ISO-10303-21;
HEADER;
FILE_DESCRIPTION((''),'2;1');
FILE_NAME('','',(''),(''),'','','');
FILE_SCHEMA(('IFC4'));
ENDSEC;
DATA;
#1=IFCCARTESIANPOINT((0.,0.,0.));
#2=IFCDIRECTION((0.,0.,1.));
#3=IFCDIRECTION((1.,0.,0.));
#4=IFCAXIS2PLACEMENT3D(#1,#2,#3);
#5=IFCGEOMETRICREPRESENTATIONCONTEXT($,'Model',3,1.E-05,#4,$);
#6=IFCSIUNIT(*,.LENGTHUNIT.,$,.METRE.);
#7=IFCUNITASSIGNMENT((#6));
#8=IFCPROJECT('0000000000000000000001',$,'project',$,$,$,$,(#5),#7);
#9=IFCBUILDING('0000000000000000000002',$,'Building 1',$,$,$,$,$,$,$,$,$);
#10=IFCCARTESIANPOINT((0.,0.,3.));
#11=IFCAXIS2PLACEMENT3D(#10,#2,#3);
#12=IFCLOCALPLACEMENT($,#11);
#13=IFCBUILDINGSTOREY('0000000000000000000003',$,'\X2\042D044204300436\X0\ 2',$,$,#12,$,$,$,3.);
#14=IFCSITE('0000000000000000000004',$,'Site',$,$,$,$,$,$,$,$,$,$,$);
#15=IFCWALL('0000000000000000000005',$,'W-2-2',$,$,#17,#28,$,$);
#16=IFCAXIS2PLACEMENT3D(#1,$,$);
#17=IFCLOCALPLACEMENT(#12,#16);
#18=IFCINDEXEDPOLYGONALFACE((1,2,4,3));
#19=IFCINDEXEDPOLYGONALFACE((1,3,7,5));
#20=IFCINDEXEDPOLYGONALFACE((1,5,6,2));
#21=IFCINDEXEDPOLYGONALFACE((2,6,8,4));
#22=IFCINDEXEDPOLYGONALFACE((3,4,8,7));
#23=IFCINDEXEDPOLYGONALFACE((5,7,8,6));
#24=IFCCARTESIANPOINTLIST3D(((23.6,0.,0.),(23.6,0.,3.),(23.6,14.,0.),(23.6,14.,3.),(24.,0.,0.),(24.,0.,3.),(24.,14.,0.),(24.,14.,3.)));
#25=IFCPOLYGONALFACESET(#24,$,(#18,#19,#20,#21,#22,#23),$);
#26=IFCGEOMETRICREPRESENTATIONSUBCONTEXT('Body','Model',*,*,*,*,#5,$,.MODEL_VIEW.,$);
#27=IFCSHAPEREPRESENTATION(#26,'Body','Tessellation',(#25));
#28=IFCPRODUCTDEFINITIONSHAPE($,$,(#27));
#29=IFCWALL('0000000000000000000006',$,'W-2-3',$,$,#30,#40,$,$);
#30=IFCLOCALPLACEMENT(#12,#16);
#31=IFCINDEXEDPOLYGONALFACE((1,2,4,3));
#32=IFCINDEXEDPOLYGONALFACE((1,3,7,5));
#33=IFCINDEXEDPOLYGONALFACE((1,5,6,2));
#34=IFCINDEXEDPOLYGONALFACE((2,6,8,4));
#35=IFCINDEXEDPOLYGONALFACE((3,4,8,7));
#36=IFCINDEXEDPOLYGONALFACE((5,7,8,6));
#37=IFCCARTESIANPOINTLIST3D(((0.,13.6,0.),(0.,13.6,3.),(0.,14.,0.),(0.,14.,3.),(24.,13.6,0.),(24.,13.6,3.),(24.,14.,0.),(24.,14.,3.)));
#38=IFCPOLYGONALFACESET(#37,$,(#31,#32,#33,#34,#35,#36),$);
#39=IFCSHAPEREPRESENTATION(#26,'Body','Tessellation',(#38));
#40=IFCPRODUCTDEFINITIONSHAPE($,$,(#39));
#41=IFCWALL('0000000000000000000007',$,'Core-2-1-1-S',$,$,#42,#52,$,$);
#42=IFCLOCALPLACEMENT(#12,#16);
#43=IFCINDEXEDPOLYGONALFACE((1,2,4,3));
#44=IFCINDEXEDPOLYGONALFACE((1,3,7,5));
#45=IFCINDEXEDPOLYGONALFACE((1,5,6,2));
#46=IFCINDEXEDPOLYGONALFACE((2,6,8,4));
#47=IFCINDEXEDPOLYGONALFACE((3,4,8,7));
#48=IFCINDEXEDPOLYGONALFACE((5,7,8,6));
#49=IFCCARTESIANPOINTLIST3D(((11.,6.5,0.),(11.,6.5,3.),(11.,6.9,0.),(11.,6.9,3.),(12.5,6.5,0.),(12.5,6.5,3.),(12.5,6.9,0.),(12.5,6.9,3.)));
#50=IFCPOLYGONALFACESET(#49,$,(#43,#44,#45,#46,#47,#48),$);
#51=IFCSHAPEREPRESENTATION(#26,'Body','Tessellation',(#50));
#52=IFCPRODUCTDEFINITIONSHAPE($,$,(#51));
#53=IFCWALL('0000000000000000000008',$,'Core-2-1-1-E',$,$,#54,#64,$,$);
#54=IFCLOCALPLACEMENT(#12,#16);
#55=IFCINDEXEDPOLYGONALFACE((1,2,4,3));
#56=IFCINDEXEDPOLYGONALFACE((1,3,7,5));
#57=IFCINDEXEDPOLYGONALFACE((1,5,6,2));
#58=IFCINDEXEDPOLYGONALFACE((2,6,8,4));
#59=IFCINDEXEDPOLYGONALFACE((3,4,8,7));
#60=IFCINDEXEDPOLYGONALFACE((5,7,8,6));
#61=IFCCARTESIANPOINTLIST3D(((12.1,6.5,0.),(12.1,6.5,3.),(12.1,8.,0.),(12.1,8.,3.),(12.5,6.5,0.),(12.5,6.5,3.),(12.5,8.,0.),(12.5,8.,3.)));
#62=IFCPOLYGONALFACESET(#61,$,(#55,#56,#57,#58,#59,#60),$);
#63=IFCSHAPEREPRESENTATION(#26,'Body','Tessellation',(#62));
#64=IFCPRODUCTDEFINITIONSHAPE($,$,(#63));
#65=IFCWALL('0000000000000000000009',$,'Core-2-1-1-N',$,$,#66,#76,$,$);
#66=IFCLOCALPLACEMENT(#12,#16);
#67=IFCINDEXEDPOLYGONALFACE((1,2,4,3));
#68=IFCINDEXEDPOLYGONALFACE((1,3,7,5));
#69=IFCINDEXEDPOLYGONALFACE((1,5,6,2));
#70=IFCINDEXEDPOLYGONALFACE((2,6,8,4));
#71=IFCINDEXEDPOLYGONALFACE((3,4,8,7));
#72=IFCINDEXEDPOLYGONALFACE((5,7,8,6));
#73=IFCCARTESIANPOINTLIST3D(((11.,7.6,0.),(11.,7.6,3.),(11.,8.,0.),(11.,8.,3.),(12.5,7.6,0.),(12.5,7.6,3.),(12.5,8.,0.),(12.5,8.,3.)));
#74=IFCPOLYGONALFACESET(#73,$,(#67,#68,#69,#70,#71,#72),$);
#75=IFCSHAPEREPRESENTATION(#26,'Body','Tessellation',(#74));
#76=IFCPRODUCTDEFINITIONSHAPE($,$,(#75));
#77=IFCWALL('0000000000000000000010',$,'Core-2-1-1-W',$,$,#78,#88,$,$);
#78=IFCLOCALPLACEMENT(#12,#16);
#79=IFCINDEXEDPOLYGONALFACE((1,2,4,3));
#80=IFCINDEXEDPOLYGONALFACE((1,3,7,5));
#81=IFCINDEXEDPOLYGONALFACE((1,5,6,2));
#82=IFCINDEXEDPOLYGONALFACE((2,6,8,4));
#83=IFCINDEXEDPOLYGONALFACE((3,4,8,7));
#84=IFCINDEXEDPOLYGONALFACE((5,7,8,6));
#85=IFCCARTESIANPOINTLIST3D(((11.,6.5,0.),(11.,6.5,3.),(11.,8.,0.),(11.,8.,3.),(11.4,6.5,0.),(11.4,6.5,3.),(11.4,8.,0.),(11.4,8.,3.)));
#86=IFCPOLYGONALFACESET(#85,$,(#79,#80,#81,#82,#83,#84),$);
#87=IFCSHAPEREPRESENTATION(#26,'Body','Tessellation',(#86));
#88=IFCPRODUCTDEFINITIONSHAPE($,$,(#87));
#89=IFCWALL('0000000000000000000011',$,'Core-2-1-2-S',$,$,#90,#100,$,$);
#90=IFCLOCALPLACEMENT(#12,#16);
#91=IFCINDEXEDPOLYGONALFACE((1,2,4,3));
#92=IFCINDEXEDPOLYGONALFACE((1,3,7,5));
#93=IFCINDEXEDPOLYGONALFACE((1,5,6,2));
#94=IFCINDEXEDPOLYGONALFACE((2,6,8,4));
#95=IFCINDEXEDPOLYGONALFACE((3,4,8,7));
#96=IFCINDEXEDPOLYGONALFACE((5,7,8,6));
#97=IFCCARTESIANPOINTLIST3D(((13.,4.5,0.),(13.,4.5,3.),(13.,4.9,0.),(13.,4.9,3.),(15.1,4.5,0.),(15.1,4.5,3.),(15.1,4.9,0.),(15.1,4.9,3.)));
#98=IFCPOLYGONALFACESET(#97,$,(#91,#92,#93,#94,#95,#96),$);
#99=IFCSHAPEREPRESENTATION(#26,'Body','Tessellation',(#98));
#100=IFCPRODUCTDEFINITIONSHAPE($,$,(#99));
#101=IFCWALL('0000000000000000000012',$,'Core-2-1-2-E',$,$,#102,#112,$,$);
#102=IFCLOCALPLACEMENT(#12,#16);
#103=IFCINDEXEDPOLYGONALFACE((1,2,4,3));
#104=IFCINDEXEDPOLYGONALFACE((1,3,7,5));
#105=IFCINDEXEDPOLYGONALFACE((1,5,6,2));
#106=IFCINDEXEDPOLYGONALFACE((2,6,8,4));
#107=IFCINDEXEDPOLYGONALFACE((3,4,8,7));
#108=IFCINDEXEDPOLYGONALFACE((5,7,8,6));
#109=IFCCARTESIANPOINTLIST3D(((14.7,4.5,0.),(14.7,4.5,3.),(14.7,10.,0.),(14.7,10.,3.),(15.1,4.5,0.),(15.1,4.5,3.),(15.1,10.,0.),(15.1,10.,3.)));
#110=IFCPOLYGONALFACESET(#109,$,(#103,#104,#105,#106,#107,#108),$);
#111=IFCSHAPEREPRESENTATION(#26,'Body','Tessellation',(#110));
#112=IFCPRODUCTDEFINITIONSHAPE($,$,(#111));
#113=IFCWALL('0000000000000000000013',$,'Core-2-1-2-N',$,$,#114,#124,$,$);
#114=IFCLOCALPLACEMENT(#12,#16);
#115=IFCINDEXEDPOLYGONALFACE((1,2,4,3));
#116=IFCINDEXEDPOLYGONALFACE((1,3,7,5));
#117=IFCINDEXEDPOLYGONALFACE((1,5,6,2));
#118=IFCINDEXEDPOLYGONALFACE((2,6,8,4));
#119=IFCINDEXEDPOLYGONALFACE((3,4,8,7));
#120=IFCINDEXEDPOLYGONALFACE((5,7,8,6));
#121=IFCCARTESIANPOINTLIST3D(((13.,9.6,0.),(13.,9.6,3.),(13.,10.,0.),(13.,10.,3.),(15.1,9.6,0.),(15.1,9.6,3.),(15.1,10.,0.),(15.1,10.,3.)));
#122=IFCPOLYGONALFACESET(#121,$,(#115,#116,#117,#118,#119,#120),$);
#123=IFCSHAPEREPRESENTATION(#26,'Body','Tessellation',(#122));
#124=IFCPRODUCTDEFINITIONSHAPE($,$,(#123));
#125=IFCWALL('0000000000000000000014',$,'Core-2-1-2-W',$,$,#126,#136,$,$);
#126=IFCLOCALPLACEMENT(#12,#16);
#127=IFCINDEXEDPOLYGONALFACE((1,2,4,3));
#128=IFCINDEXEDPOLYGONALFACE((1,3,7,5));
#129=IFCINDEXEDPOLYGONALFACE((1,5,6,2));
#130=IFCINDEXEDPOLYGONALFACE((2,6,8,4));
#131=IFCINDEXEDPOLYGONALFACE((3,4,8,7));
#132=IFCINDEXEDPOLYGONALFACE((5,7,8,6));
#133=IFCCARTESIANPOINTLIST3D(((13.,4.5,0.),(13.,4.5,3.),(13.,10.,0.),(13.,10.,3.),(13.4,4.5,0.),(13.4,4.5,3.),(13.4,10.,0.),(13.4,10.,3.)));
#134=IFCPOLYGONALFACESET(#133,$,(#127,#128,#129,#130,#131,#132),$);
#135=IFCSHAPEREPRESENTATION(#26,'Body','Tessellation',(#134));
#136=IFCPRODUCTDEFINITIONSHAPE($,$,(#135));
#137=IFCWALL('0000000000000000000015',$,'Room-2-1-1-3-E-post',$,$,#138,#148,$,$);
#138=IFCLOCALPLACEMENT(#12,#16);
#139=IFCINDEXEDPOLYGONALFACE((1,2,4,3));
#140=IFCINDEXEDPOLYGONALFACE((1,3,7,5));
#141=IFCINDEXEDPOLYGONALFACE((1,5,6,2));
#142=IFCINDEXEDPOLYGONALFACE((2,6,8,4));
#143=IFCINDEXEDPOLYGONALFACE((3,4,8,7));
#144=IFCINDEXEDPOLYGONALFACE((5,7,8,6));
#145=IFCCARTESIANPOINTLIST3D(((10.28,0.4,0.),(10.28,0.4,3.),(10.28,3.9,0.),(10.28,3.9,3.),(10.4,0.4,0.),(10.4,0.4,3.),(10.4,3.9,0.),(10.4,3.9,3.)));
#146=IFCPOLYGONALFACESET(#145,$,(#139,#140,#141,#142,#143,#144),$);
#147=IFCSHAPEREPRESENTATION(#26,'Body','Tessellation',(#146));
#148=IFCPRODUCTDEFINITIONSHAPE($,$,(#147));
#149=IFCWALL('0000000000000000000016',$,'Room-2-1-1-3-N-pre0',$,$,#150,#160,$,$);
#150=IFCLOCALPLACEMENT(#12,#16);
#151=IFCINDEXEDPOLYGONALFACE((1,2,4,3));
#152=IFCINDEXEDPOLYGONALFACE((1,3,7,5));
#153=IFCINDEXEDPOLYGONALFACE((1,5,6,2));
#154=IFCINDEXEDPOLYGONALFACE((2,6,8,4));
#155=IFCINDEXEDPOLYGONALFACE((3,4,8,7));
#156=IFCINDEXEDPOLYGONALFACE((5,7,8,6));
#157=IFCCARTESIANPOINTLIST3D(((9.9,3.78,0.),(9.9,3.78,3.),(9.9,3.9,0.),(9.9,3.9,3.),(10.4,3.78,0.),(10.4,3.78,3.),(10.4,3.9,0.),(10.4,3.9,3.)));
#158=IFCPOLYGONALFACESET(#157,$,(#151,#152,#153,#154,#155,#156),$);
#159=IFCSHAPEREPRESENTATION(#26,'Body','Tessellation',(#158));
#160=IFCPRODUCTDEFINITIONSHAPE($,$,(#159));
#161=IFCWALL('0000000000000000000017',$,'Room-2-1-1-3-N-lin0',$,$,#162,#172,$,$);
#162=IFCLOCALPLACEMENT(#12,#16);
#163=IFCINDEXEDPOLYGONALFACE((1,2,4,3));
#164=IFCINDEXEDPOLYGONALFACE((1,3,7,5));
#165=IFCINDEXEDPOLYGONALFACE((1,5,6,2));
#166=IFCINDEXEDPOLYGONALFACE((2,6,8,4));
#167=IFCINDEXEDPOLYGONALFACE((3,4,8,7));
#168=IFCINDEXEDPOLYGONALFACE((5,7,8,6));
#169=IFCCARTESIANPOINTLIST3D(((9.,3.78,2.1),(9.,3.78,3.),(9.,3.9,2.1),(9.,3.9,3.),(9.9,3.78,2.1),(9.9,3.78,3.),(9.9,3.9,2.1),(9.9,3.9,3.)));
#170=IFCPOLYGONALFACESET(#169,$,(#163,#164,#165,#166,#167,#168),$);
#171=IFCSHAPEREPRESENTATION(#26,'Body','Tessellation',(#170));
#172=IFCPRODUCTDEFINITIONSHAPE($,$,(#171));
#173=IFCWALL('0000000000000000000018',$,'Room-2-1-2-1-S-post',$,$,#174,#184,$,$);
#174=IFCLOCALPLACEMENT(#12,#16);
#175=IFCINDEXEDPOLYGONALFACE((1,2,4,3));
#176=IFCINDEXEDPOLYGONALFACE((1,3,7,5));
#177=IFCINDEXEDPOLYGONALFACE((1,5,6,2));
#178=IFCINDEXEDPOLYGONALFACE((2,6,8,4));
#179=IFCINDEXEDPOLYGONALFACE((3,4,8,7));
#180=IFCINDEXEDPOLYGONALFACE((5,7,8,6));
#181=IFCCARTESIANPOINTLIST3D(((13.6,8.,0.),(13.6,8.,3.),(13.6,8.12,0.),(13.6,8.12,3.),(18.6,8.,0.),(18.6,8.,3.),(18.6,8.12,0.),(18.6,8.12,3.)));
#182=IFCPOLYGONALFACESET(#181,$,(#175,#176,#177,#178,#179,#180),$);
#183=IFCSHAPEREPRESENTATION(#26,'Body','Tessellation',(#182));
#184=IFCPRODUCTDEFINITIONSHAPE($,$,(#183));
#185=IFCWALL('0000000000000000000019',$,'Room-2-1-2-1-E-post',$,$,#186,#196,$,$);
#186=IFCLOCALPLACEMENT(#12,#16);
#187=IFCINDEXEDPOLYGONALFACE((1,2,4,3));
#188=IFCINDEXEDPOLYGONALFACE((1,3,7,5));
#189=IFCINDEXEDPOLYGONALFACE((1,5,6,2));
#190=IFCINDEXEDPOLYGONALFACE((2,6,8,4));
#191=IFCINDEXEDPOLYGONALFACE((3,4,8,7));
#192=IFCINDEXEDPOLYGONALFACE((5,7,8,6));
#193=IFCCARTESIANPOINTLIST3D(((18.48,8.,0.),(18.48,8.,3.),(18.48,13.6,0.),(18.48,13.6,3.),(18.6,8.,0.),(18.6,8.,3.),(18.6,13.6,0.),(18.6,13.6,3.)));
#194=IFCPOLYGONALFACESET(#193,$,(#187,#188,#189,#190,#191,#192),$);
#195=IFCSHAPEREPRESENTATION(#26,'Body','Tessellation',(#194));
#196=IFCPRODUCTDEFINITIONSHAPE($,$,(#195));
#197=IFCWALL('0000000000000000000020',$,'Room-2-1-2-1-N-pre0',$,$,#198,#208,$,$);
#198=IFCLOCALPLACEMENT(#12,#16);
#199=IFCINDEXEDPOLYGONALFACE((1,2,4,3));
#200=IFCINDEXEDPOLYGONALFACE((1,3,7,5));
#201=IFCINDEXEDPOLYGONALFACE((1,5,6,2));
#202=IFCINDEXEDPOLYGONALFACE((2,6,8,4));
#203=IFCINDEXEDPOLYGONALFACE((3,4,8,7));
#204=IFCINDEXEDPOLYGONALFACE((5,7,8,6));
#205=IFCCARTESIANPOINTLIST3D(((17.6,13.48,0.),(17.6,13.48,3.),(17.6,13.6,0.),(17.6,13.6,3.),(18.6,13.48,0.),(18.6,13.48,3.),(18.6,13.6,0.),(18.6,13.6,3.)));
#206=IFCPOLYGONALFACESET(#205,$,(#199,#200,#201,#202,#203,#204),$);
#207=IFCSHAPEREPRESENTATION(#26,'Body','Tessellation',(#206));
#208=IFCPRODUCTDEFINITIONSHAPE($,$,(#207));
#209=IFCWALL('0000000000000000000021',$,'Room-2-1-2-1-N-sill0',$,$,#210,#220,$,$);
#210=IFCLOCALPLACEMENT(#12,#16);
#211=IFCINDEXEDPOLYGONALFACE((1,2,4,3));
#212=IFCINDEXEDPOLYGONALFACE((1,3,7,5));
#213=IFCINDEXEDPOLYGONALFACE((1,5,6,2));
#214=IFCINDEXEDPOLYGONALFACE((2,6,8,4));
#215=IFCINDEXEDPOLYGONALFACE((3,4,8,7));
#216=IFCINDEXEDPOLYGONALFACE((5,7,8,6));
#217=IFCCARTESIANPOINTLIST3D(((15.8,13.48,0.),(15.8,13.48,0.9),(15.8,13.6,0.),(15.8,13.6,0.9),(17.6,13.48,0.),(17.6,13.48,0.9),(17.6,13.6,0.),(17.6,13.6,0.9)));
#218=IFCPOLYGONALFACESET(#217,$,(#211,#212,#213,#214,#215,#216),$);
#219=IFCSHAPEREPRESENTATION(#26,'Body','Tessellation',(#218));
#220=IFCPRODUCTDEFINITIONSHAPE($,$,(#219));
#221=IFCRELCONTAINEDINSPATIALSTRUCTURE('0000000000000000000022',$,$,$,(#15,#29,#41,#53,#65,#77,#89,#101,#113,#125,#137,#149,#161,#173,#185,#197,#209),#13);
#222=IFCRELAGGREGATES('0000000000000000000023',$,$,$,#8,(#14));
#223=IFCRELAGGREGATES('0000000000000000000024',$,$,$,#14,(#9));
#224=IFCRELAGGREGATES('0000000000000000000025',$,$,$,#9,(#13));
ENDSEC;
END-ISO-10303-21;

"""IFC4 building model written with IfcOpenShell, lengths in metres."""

from ifc_helpers import new_model, si_unit, frame, origin_with_axes, place, context, subcontext, project, spatial, indexed_curve, outline, extrude, element, save


model = new_model("IFC4")

# Units and contexts
model_context = context("Model", 3, precision=1e-05, world=origin_with_axes())
body_context = subcontext(model_context, "Body", "Model", "MODEL_VIEW")
ifc_project = project(units=[si_unit("LENGTHUNIT", "METRE")], contexts=[model_context])

# Site, building, storey
site = spatial("IfcSite", under=ifc_project, Name="Site")
building = spatial("IfcBuilding", under=site, Name="Building 1")
storey_placement = place(None, frame((0.0, 0.0, 3.0), z_axis=(0.0, 0.0, 1.0), x_axis=(1.0, 0.0, 0.0)))
storey = spatial("IfcBuildingStorey", under=building, at=storey_placement, Name="Этаж 2", Elevation=3.0)

# Walls
wall_1_placement = place(storey_placement, frame((24.0, 0.0, 0.0), z_axis=(0.0, 0.0, 1.0), x_axis=(0.0, 1.0, 0.0)))
element("IfcWall", 1, at=wall_1_placement, inside=storey, Name="W-2-2", context=body_context, shape_type="SweptSolid", body=[
    extrude(outline(indexed_curve([(0.0, 0.0), (0.0, 0.4), (14.0, 0.4), (14.0, 0.0), (0.0, 0.0)], self_intersect=False)), origin_with_axes(), (0.0, 0.0, 1.0), 3.0),
])
wall_2_placement = place(storey_placement, frame((24.0, 14.0, 0.0), z_axis=(0.0, 0.0, 1.0), x_axis=(-1.0, 0.0, 0.0)))
element("IfcWall", 2, at=wall_2_placement, inside=storey, Name="W-2-3", context=body_context, shape_type="SweptSolid", body=[
    extrude(outline(indexed_curve([(0.0, 0.0), (0.0, 0.4), (24.0, 0.4), (24.0, 0.0), (0.0, 0.0)], self_intersect=False)), origin_with_axes(), (0.0, 0.0, 1.0), 3.0),
])
for number, where, z_axis, x_axis, name in (
    (3, (11.0, 6.5, 0.0), (0.0, 0.0, 1.0), (1.0, 0.0, 0.0), "Core-2-1-1-S"),
    (4, (12.5, 6.5, 0.0), (0.0, 0.0, 1.0), (0.0, 1.0, 0.0), "Core-2-1-1-E"),
    (5, (12.5, 8.0, 0.0), (0.0, 0.0, 1.0), (-1.0, 0.0, 0.0), "Core-2-1-1-N"),
    (6, (11.0, 8.0, 0.0), (0.0, 0.0, 1.0), (0.0, -1.0, 0.0), "Core-2-1-1-W"),
):
    element("IfcWall", number, at=place(storey_placement, frame(where, z_axis=z_axis, x_axis=x_axis)), inside=storey, Name=name, context=body_context, shape_type="SweptSolid", body=[
        extrude(outline(indexed_curve([(0.0, 0.0), (0.0, 0.4), (1.5, 0.4), (1.5, 0.0), (0.0, 0.0)], self_intersect=False)), origin_with_axes(), (0.0, 0.0, 1.0), 3.0),
    ])
wall_3_placement = place(storey_placement, frame((13.0, 4.5, 0.0), z_axis=(0.0, 0.0, 1.0), x_axis=(1.0, 0.0, 0.0)))
element("IfcWall", 7, at=wall_3_placement, inside=storey, Name="Core-2-1-2-S", context=body_context, shape_type="SweptSolid", body=[
    extrude(outline(indexed_curve([(0.0, 0.0), (0.0, 0.4), (2.1, 0.4), (2.1, 0.0), (0.0, 0.0)], self_intersect=False)), origin_with_axes(), (0.0, 0.0, 1.0), 3.0),
])
wall_4_placement = place(storey_placement, frame((15.1, 4.5, 0.0), z_axis=(0.0, 0.0, 1.0), x_axis=(0.0, 1.0, 0.0)))
element("IfcWall", 8, at=wall_4_placement, inside=storey, Name="Core-2-1-2-E", context=body_context, shape_type="SweptSolid", body=[
    extrude(outline(indexed_curve([(0.0, 0.0), (0.0, 0.4), (5.5, 0.4), (5.5, 0.0), (0.0, 0.0)], self_intersect=False)), origin_with_axes(), (0.0, 0.0, 1.0), 3.0),
])
wall_5_placement = place(storey_placement, frame((15.1, 10.0, 0.0), z_axis=(0.0, 0.0, 1.0), x_axis=(-1.0, 0.0, 0.0)))
element("IfcWall", 9, at=wall_5_placement, inside=storey, Name="Core-2-1-2-N", context=body_context, shape_type="SweptSolid", body=[
    extrude(outline(indexed_curve([(0.0, 0.0), (0.0, 0.4), (2.1, 0.4), (2.1, 0.0), (0.0, 0.0)], self_intersect=False)), origin_with_axes(), (0.0, 0.0, 1.0), 3.0),
])
wall_6_placement = place(storey_placement, frame((13.0, 10.0, 0.0), z_axis=(0.0, 0.0, 1.0), x_axis=(0.0, -1.0, 0.0)))
element("IfcWall", 10, at=wall_6_placement, inside=storey, Name="Core-2-1-2-W", context=body_context, shape_type="SweptSolid", body=[
    extrude(outline(indexed_curve([(0.0, 0.0), (0.0, 0.4), (5.5, 0.4), (5.5, 0.0), (0.0, 0.0)], self_intersect=False)), origin_with_axes(), (0.0, 0.0, 1.0), 3.0),
])
wall_7_placement = place(storey_placement, frame((10.4, 0.4, 0.0), z_axis=(0.0, 0.0, 1.0), x_axis=(0.0, 1.0, 0.0)))
element("IfcWall", 11, at=wall_7_placement, inside=storey, Name="Room-2-1-1-3-E-post", context=body_context, shape_type="SweptSolid", body=[
    extrude(outline(indexed_curve([(0.0, 0.0), (0.0, 0.12), (3.5, 0.12), (3.5, 0.0), (0.0, 0.0)], self_intersect=False)), origin_with_axes(), (0.0, 0.0, 1.0), 3.0),
])
wall_8_placement = place(storey_placement, frame((10.4, 3.9, 0.0), z_axis=(0.0, 0.0, 1.0), x_axis=(-1.0, 0.0, 0.0)))
element("IfcWall", 12, at=wall_8_placement, inside=storey, Name="Room-2-1-1-3-N-pre0", context=body_context, shape_type="SweptSolid", body=[
    extrude(outline(indexed_curve([(0.0, 0.0), (0.0, 0.12), (0.5, 0.12), (0.5, 0.0), (0.0, 0.0)], self_intersect=False)), origin_with_axes(), (0.0, 0.0, 1.0), 3.0),
])
wall_9_placement = place(storey_placement, frame((9.9, 3.9, 2.1), z_axis=(0.0, 0.0, 1.0), x_axis=(-1.0, 0.0, 0.0)))
element("IfcWall", 13, at=wall_9_placement, inside=storey, Name="Room-2-1-1-3-N-lin0", context=body_context, shape_type="SweptSolid", body=[
    extrude(outline(indexed_curve([(0.0, 0.0), (0.0, 0.12), (0.9, 0.12), (0.9, 0.0), (0.0, 0.0)], self_intersect=False)), origin_with_axes(), (0.0, 0.0, 1.0), 0.9),
])
wall_10_placement = place(storey_placement, frame((13.6, 8.0, 0.0), z_axis=(0.0, 0.0, 1.0), x_axis=(1.0, 0.0, 0.0)))
element("IfcWall", 14, at=wall_10_placement, inside=storey, Name="Room-2-1-2-1-S-post", context=body_context, shape_type="SweptSolid", body=[
    extrude(outline(indexed_curve([(0.0, 0.0), (0.0, 0.12), (5.0, 0.12), (5.0, 0.0), (0.0, 0.0)], self_intersect=False)), origin_with_axes(), (0.0, 0.0, 1.0), 3.0),
])
wall_11_placement = place(storey_placement, frame((18.6, 8.0, 0.0), z_axis=(0.0, 0.0, 1.0), x_axis=(0.0, 1.0, 0.0)))
element("IfcWall", 15, at=wall_11_placement, inside=storey, Name="Room-2-1-2-1-E-post", context=body_context, shape_type="SweptSolid", body=[
    extrude(outline(indexed_curve([(0.0, 0.0), (0.0, 0.12), (5.6, 0.12), (5.6, 0.0), (0.0, 0.0)], self_intersect=False)), origin_with_axes(), (0.0, 0.0, 1.0), 3.0),
])
wall_12_placement = place(storey_placement, frame((18.6, 13.6, 0.0), z_axis=(0.0, 0.0, 1.0), x_axis=(-1.0, 0.0, 0.0)))
element("IfcWall", 16, at=wall_12_placement, inside=storey, Name="Room-2-1-2-1-N-pre0", context=body_context, shape_type="SweptSolid", body=[
    extrude(outline(indexed_curve([(0.0, 0.0), (0.0, 0.12), (1.0, 0.12), (1.0, 0.0), (0.0, 0.0)], self_intersect=False)), origin_with_axes(), (0.0, 0.0, 1.0), 3.0),
])
wall_13_placement = place(storey_placement, frame((17.6, 13.6, 0.0), z_axis=(0.0, 0.0, 1.0), x_axis=(-1.0, 0.0, 0.0)))
element("IfcWall", 17, at=wall_13_placement, inside=storey, Name="Room-2-1-2-1-N-sill0", context=body_context, shape_type="SweptSolid", body=[
    extrude(outline(indexed_curve([(0.0, 0.0), (0.0, 0.12), (1.8, 0.12), (1.8, 0.0), (0.0, 0.0)], self_intersect=False)), origin_with_axes(), (0.0, 0.0, 1.0), 0.9),
])

save(model, "model.ifc")
